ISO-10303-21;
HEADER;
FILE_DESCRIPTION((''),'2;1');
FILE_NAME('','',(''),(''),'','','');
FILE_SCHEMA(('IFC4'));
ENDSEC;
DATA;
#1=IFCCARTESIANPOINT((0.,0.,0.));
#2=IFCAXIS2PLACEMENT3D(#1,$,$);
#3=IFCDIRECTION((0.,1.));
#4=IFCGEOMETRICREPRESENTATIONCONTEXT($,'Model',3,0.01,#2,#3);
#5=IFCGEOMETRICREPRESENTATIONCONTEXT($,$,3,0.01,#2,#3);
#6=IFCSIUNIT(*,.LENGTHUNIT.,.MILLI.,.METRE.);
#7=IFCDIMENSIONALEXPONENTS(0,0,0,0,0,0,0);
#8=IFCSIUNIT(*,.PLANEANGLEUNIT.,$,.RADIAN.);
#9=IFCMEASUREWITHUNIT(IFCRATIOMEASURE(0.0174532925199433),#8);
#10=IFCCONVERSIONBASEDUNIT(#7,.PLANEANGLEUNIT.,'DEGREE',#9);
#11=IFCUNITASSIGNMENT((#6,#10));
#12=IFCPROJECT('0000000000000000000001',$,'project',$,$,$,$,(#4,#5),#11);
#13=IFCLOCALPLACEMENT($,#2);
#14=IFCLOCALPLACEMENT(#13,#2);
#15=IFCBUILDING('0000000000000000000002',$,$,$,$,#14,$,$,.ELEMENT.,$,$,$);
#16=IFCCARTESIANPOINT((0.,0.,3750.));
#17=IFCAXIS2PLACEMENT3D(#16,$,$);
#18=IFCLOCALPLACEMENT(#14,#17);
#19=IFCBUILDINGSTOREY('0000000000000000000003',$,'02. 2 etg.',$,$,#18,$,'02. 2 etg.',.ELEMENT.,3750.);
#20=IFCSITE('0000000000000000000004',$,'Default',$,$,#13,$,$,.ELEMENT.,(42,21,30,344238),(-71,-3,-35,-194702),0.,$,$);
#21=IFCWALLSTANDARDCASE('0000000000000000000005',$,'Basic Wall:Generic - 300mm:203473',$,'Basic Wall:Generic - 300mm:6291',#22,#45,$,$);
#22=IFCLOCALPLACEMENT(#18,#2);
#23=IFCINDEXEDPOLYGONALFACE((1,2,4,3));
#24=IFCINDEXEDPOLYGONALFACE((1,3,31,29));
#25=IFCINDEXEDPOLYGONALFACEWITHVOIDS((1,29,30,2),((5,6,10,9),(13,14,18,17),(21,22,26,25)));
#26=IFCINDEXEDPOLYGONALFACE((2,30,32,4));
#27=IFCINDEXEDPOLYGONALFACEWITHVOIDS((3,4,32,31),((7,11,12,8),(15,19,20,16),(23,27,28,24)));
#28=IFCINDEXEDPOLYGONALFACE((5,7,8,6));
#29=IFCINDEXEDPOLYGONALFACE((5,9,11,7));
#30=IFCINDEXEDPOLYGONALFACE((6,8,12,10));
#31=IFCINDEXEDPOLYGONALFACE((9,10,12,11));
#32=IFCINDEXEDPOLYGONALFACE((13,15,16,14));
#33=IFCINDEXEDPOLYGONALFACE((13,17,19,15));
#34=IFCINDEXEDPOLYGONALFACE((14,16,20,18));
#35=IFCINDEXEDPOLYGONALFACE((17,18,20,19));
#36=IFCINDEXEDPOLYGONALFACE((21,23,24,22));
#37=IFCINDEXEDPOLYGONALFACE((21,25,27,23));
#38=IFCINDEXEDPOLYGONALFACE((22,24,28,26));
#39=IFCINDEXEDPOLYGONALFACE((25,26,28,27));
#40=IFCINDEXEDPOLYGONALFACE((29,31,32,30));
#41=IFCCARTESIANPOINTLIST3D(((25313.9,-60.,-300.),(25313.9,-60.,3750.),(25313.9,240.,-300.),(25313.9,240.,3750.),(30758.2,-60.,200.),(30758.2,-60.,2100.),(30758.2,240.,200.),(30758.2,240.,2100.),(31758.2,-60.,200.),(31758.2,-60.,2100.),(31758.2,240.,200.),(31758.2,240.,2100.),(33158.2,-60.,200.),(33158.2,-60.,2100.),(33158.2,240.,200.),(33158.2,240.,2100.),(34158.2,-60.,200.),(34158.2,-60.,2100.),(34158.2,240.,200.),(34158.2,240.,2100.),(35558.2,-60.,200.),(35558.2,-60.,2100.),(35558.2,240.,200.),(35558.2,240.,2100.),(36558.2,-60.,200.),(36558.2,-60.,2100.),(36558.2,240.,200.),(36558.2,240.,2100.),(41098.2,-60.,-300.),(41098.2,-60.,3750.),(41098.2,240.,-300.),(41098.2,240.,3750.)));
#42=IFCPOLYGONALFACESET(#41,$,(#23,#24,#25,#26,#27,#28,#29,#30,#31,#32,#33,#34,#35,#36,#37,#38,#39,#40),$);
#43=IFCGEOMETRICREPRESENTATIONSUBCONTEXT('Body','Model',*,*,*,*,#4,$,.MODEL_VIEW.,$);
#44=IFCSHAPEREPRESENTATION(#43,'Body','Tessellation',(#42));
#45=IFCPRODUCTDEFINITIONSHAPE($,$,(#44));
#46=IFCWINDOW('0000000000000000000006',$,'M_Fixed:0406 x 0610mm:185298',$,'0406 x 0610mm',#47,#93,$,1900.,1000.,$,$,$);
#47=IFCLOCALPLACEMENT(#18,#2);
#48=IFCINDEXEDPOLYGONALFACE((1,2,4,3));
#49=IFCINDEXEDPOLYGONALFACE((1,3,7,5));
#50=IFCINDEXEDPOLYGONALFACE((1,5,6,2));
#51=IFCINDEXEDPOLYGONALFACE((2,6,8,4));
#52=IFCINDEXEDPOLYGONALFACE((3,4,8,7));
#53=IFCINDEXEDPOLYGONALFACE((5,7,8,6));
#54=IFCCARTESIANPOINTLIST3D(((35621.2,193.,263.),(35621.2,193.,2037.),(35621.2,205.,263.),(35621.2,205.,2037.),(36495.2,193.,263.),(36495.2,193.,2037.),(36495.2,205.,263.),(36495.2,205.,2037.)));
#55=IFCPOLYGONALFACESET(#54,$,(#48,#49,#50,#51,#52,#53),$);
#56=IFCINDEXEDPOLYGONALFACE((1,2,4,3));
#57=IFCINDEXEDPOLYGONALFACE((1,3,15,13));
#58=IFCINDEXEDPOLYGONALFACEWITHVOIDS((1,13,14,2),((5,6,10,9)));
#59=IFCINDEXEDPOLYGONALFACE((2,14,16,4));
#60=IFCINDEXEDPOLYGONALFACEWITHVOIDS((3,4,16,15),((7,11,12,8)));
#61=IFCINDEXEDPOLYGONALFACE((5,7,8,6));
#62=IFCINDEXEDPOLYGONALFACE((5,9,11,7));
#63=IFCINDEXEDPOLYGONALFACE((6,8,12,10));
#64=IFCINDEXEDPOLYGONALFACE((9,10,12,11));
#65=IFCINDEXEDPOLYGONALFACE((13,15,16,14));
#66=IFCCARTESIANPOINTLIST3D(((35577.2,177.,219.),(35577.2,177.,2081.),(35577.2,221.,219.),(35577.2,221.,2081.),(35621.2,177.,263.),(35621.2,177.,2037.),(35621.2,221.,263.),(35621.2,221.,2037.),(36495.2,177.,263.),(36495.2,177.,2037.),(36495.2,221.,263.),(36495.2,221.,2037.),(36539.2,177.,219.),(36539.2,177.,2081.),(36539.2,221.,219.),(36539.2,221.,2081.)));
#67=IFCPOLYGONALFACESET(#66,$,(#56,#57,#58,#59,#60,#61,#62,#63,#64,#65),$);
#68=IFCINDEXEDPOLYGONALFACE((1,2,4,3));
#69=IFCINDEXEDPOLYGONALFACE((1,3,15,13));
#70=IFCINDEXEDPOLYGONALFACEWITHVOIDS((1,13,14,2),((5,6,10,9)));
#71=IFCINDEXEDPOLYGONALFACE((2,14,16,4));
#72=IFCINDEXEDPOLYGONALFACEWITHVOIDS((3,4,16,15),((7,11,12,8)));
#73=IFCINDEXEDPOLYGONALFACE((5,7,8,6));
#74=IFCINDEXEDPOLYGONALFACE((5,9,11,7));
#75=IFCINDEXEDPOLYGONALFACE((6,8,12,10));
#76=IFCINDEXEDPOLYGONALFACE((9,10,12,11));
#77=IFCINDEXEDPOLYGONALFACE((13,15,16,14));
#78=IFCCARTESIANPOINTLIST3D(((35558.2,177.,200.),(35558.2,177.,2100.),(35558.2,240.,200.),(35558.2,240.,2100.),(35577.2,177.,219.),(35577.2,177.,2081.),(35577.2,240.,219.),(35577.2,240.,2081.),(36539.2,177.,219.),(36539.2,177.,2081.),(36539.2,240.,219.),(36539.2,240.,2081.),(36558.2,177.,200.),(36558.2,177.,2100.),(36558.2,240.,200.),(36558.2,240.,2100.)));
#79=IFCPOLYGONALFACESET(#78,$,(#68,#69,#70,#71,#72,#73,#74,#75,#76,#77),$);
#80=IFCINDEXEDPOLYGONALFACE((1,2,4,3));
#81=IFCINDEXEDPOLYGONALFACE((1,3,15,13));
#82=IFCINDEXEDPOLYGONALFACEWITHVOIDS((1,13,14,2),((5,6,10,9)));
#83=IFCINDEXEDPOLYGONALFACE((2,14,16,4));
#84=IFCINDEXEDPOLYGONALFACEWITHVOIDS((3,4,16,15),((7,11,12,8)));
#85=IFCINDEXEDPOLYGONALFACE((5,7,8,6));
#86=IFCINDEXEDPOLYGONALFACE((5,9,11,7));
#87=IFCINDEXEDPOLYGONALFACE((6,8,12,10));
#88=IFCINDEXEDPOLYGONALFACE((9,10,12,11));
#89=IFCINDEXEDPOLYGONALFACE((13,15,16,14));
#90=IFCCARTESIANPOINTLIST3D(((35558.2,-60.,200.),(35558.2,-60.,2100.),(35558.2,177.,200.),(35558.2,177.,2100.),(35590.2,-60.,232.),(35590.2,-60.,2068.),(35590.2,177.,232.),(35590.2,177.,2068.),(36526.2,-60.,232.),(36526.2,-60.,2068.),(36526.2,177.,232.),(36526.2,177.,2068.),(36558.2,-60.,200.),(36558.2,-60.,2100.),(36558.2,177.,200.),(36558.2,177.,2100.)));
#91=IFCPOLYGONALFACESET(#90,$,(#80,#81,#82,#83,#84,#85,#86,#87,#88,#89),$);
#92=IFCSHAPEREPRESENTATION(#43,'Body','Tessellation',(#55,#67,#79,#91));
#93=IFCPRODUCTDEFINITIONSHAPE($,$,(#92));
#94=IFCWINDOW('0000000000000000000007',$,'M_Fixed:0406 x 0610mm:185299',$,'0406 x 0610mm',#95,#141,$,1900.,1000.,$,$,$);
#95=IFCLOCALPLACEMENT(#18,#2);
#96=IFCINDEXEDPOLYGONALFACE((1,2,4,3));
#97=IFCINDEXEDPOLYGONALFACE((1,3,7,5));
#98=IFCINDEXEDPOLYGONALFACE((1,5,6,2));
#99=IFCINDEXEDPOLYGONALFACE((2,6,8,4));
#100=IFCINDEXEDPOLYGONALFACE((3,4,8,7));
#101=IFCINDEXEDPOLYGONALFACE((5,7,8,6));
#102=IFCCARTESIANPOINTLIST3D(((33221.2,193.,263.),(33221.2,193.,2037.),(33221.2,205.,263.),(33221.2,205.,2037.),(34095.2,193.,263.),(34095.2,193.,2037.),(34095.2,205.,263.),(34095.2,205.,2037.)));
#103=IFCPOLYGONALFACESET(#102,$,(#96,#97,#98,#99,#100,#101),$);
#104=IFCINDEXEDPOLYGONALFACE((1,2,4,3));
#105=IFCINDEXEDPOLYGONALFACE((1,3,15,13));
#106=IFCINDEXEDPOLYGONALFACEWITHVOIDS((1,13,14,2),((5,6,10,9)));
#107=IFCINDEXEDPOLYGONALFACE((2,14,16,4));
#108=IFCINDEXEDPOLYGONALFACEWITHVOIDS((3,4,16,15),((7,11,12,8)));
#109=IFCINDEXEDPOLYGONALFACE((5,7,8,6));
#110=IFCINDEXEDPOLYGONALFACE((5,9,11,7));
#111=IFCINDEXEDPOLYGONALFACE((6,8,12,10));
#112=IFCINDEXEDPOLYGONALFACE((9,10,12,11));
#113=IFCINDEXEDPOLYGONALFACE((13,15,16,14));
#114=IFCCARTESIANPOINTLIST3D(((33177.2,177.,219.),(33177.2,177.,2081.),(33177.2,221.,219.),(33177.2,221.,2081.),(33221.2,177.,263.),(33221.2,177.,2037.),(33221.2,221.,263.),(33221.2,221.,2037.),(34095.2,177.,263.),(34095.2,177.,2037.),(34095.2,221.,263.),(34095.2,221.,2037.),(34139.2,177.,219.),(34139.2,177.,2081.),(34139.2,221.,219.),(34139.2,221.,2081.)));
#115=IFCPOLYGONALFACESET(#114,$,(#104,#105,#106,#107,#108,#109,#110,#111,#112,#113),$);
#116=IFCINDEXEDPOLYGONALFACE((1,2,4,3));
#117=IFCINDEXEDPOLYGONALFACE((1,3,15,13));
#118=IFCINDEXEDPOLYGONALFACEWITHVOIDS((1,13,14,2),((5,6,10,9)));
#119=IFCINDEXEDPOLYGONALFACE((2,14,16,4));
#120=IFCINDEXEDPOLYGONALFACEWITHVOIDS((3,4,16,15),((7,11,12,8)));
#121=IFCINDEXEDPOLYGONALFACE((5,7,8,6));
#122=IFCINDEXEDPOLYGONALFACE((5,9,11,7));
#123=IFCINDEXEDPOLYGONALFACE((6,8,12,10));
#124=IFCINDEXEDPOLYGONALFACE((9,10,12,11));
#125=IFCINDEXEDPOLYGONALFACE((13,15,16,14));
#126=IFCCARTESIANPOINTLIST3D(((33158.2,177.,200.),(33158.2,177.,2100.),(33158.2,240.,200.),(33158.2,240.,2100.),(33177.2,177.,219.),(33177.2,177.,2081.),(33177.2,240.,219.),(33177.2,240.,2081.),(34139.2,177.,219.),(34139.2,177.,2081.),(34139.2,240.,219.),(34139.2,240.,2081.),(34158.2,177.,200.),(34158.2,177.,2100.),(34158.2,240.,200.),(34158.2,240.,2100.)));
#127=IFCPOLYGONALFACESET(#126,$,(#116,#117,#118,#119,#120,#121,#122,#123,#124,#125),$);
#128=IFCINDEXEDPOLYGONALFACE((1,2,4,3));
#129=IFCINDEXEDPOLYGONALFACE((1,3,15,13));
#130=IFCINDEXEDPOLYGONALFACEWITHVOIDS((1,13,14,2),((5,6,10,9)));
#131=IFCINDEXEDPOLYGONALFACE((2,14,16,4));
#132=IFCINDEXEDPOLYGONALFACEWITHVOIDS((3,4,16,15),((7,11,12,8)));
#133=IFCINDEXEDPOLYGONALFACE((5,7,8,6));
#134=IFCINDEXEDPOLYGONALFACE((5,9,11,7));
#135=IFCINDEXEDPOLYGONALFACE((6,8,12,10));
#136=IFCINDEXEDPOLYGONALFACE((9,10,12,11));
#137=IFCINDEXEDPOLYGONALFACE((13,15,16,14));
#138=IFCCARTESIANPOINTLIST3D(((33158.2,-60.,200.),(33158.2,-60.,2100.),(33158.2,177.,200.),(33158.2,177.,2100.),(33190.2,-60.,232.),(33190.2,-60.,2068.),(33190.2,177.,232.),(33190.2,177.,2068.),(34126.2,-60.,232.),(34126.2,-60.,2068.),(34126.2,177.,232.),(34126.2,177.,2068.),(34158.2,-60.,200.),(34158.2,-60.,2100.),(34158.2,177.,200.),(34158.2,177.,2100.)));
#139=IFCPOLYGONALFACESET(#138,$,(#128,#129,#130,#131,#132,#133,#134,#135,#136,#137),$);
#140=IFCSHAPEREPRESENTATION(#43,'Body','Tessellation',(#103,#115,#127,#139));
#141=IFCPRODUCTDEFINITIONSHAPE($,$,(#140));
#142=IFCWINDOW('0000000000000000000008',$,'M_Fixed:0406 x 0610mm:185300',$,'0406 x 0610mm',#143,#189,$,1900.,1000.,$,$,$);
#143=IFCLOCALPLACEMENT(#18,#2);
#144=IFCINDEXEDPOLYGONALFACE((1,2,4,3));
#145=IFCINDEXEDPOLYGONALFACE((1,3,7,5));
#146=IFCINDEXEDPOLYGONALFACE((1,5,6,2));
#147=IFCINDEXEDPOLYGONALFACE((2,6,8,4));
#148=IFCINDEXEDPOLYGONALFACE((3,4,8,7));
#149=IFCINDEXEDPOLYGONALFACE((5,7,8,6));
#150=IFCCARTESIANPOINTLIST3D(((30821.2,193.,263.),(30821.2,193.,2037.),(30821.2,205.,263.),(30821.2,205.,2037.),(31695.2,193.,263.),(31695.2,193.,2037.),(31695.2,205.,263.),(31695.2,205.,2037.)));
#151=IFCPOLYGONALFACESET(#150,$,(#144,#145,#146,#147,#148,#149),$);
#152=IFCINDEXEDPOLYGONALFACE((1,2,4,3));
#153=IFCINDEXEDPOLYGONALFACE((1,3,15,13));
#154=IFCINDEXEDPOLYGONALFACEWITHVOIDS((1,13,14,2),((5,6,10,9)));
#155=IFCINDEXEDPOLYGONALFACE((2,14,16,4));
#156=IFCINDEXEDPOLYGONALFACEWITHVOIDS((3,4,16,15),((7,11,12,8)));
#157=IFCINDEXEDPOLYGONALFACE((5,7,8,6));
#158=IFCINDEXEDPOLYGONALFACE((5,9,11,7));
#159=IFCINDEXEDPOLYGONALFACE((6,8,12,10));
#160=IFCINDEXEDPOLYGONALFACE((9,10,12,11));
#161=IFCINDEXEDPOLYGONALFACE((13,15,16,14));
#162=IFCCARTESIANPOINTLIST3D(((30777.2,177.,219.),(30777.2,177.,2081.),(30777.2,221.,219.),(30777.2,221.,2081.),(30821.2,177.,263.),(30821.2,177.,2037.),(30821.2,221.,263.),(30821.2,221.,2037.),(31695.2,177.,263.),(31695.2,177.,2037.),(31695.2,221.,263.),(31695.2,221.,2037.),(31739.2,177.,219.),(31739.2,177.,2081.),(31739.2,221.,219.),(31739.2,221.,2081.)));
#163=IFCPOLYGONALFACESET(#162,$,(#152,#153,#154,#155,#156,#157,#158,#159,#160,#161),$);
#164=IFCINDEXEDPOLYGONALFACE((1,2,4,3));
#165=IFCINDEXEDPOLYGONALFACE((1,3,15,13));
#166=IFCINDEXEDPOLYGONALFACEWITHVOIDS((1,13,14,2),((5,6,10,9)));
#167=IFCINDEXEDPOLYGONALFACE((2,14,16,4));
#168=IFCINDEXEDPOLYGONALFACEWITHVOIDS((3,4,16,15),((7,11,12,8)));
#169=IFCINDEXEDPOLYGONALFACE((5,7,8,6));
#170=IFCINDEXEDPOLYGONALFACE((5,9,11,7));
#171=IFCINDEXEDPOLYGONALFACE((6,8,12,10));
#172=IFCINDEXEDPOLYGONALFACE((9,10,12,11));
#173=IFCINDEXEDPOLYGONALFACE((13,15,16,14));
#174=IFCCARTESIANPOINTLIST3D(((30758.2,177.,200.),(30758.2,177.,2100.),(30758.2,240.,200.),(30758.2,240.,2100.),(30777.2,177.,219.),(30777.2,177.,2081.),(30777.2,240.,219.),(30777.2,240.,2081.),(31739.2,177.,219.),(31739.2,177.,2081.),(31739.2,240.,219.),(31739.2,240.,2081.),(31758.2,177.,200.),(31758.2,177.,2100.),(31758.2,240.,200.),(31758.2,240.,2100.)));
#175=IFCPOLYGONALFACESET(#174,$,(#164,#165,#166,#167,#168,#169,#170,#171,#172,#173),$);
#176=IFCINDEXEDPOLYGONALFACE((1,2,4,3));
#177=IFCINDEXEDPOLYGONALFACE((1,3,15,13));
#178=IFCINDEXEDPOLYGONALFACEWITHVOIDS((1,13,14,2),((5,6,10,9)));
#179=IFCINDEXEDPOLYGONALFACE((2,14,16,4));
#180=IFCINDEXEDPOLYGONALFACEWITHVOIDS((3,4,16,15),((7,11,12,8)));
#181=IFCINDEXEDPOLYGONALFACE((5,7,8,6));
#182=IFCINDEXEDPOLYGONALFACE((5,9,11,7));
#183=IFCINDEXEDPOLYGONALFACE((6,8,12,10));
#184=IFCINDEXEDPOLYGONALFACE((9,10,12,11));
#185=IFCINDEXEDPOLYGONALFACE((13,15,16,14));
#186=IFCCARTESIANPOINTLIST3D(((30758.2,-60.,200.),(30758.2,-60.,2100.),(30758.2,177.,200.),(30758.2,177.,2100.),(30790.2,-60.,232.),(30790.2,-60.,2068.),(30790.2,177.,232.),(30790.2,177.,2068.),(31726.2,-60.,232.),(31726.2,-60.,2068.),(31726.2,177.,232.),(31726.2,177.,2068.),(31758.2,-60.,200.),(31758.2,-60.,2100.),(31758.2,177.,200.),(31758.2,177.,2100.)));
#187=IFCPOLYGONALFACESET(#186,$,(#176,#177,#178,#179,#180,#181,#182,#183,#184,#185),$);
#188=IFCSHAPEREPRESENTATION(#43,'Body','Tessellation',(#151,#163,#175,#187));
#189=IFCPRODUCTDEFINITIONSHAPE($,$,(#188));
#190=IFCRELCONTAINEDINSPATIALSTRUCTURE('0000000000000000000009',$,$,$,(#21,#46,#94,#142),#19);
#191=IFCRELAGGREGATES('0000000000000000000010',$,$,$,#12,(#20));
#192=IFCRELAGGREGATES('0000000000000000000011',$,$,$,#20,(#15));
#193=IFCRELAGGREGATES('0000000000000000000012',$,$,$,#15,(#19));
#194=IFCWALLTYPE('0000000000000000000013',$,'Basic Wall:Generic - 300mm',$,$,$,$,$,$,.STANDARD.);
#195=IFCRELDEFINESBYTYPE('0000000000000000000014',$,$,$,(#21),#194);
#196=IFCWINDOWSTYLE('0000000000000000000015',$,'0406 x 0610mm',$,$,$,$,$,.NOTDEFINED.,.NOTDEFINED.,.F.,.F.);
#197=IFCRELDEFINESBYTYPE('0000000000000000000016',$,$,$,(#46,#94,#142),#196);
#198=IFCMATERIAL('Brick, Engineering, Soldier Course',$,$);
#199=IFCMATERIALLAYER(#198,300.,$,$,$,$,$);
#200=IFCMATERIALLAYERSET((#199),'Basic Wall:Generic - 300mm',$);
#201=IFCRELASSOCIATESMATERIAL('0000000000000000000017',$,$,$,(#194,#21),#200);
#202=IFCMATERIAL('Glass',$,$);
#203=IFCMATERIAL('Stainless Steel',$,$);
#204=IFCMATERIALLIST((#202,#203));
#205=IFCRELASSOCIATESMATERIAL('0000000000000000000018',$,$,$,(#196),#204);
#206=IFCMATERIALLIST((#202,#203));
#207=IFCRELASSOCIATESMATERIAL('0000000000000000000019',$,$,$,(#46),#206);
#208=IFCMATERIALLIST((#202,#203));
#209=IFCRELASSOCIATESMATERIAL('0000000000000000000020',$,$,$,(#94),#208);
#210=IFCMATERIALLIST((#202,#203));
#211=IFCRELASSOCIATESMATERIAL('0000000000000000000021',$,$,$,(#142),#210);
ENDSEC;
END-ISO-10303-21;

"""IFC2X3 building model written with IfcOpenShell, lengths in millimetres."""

from ifc_helpers import new_model, entity, si_unit, converted_unit, direction, frame, frame_2d, origin, place, context, subcontext, project, spatial, polyline, rectangle, outline, extrude, source, transform, mapped, material, material_list, layer, layer_set, layer_usage, type_object, type_shapes, element, fill, save


model = new_model("IFC2X3")

# Units and contexts
model_context = context("Model", 3, precision=0.01, world=origin(), true_north=direction((0.0, 1.0)))
context_of_model = context(None, 3, precision=0.01, world=origin(), true_north=direction((0.0, 1.0)))
body_context = subcontext(model_context, "Body", "Model", "MODEL_VIEW")
ifc_project = project(units=[si_unit("LENGTHUNIT", "METRE", prefix="MILLI"), converted_unit("PLANEANGLEUNIT", "DEGREE", entity("IfcRatioMeasure", 0.0174532925199433), si_unit("PLANEANGLEUNIT", "RADIAN"), dimensions=[0, 0, 0, 0, 0, 0, 0])], contexts=[model_context, context_of_model])

# Site, building, storey
site_placement = place(None, origin())
site = spatial("IfcSite", under=ifc_project, at=site_placement, Name="Default", CompositionType="ELEMENT", RefLatitude=(42, 21, 30, 344238), RefLongitude=(-71, -3, -35, -194702), RefElevation=0.0)
building_placement = place(site_placement, origin())
building = spatial("IfcBuilding", under=site, at=building_placement, CompositionType="ELEMENT")
storey_placement = place(building_placement, frame((0.0, 0.0, 3750.0)))
storey = spatial("IfcBuildingStorey", under=building, at=storey_placement, Name="02. 2 etg.", LongName="02. 2 etg.", CompositionType="ELEMENT", Elevation=3750.0)

# Shared definitions
ifc_material_1 = material(Name="Brick, Engineering, Soldier Course")
ifc_layer_1 = layer(ifc_material_1, 300.0)
ifc_layer_set_1 = layer_set([ifc_layer_1], Name="Basic Wall:Generic - 300mm")
wall_type_1 = type_object("IfcWallType", Name="Basic Wall:Generic - 300mm", PredefinedType="STANDARD", material=ifc_layer_set_1)

# Wall, openings, windows
ifc_layer_usage_1 = layer_usage(ifc_layer_set_1, "AXIS2", "NEGATIVE", 150.0)
wall_1_placement = place(storey_placement, frame((25313.9, 90.0, -300.0)))
wall_1 = element("IfcWallStandardCase", 1, at=wall_1_placement, inside=storey, type_object=wall_type_1, material=ifc_layer_usage_1, Name="Basic Wall:Generic - 300mm:203473", ObjectType="Basic Wall:Generic - 300mm:6291", context=body_context, shape_type="SweptSolid", body=[
    extrude(rectangle(XDim=15784.3, YDim=300.0, at=frame_2d((7892.2, 0.0), x_axis=(-1.0, 0.0))), origin(), (0.0, 0.0, 1.0), 4050.0),
])
opening_1_placement = place(wall_1_placement, frame((10244.3, -150.0, 500.0)))
opening_1 = element("IfcOpeningElement", 2, at=opening_1_placement, cuts=wall_1, ObjectType="Opening", context=body_context, shape_type="SweptSolid", body=[
    extrude(rectangle(XDim=1900.0, YDim=1000.0, at=frame_2d((950.0, 500.0), x_axis=(1.0, 0.0))), frame((0.0, 0.0, 0.0), z_axis=(0.0, 1.0, 0.0), x_axis=(0.0, 0.0, 1.0)), (0.0, 0.0, 1.0), 300.0),
])
opening_2_placement = place(wall_1_placement, frame((7844.3, -150.0, 500.0)))
opening_2 = element("IfcOpeningElement", 3, at=opening_2_placement, cuts=wall_1, ObjectType="Opening", context=body_context, shape_type="SweptSolid", body=[
    extrude(rectangle(XDim=1900.0, YDim=1000.0, at=frame_2d((950.0, 500.0), x_axis=(1.0, 0.0))), frame((0.0, 0.0, 0.0), z_axis=(0.0, 1.0, 0.0), x_axis=(0.0, 0.0, 1.0)), (0.0, 0.0, 1.0), 300.0),
])
opening_3_placement = place(wall_1_placement, frame((5444.3, -150.0, 500.0)))
opening_3 = element("IfcOpeningElement", 4, at=opening_3_placement, cuts=wall_1, ObjectType="Opening", context=body_context, shape_type="SweptSolid", body=[
    extrude(rectangle(XDim=1900.0, YDim=1000.0, at=frame_2d((950.0, 500.0), x_axis=(1.0, 0.0))), frame((0.0, 0.0, 0.0), z_axis=(0.0, 1.0, 0.0), x_axis=(0.0, 0.0, 1.0)), (0.0, 0.0, 1.0), 300.0),
])
ifc_material_2 = material(Name="Glass")
ifc_material_3 = material(Name="Stainless Steel")
ifc_material_list_1 = material_list([ifc_material_2, ifc_material_3])
ifc_material_list_2 = material_list([ifc_material_2, ifc_material_3])
window_style = type_object("IfcWindowStyle", Name="0406 x 0610mm", ConstructionType="NOTDEFINED", OperationType="NOTDEFINED", ParameterTakesPrecedence=False, Sizeable=False, material=ifc_material_list_2)
shared_shape_1 = source(origin(), body_context, "Body", "SweptSolid", [
    extrude(rectangle(XDim=874.0, YDim=12.0, at=frame_2d((0.0, 0.0), x_axis=(1.0, 0.0))), frame((500.0, 285.0, 63.0), z_axis=(0.0, 0.0, 1.0), x_axis=(-1.0, 0.0, 0.0)), (0.0, 0.0, 1.0), 1774.0),
    extrude(outline(polyline([(-481.0, -931.0), (481.0, -931.0), (481.0, 931.0), (-481.0, 931.0), (-481.0, -931.0)]), holes=[polyline([(-437.0, -887.0), (-437.0, 887.0), (437.0, 887.0), (437.0, -887.0), (-437.0, -887.0)])]), frame((500.0, 307.0, 950.0), z_axis=(0.0, -1.0, 0.0), x_axis=(-1.0, 0.0, 0.0)), (0.0, 0.0, 1.0), 44.0),
    extrude(outline(polyline([(-500.0, -950.0), (500.0, -950.0), (500.0, 950.0), (-500.0, 950.0), (-500.0, -950.0)]), holes=[polyline([(-481.0, -931.0), (-481.0, 931.0), (481.0, 931.0), (481.0, -931.0), (-481.0, -931.0)])]), frame((500.0, 326.0, 950.0), z_axis=(0.0, -1.0, 0.0), x_axis=(-1.0, 0.0, 0.0)), (0.0, 0.0, 1.0), 63.0),
    extrude(outline(polyline([(-500.0, -950.0), (500.0, -950.0), (500.0, 950.0), (-500.0, 950.0), (-500.0, -950.0)]), holes=[polyline([(-468.0, -918.0), (-468.0, 918.0), (468.0, 918.0), (468.0, -918.0), (-468.0, -918.0)])]), frame((500.0, 263.0, 950.0), z_axis=(0.0, -1.0, 0.0), x_axis=(-1.0, 0.0, 0.0)), (0.0, 0.0, 1.0), 237.0),
])
type_shapes(window_style, [shared_shape_1])
window_1_placement = place(opening_1_placement, frame((0.0, -26.0, 0.0)))
window_1 = element("IfcWindow", 5, at=window_1_placement, inside=storey, type_object=window_style, material=ifc_material_list_1, Name="M_Fixed:0406 x 0610mm:185298", ObjectType="0406 x 0610mm", OverallHeight=1900.0, OverallWidth=1000.0, context=body_context, shape_type="MappedRepresentation", body=[
    mapped(shared_shape_1, transform((0.0, 0.0, 0.0), scale=1.0)),
])
fill(opening_1, window_1)
ifc_material_list_3 = material_list([ifc_material_2, ifc_material_3])
window_2_placement = place(opening_2_placement, frame((0.0, -26.0, 0.0)))
window_2 = element("IfcWindow", 6, at=window_2_placement, inside=storey, type_object=window_style, material=ifc_material_list_3, Name="M_Fixed:0406 x 0610mm:185299", ObjectType="0406 x 0610mm", OverallHeight=1900.0, OverallWidth=1000.0, context=body_context, shape_type="MappedRepresentation", body=[
    mapped(shared_shape_1, transform((0.0, 0.0, 0.0), scale=1.0)),
])
fill(opening_2, window_2)
ifc_material_list_4 = material_list([ifc_material_2, ifc_material_3])
window_3_placement = place(opening_3_placement, frame((0.0, -26.0, 0.0)))
window_3 = element("IfcWindow", 7, at=window_3_placement, inside=storey, type_object=window_style, material=ifc_material_list_4, Name="M_Fixed:0406 x 0610mm:185300", ObjectType="0406 x 0610mm", OverallHeight=1900.0, OverallWidth=1000.0, context=body_context, shape_type="MappedRepresentation", body=[
    mapped(shared_shape_1, transform((0.0, 0.0, 0.0), scale=1.0)),
])
fill(opening_3, window_3)

save(model, "model.ifc")
